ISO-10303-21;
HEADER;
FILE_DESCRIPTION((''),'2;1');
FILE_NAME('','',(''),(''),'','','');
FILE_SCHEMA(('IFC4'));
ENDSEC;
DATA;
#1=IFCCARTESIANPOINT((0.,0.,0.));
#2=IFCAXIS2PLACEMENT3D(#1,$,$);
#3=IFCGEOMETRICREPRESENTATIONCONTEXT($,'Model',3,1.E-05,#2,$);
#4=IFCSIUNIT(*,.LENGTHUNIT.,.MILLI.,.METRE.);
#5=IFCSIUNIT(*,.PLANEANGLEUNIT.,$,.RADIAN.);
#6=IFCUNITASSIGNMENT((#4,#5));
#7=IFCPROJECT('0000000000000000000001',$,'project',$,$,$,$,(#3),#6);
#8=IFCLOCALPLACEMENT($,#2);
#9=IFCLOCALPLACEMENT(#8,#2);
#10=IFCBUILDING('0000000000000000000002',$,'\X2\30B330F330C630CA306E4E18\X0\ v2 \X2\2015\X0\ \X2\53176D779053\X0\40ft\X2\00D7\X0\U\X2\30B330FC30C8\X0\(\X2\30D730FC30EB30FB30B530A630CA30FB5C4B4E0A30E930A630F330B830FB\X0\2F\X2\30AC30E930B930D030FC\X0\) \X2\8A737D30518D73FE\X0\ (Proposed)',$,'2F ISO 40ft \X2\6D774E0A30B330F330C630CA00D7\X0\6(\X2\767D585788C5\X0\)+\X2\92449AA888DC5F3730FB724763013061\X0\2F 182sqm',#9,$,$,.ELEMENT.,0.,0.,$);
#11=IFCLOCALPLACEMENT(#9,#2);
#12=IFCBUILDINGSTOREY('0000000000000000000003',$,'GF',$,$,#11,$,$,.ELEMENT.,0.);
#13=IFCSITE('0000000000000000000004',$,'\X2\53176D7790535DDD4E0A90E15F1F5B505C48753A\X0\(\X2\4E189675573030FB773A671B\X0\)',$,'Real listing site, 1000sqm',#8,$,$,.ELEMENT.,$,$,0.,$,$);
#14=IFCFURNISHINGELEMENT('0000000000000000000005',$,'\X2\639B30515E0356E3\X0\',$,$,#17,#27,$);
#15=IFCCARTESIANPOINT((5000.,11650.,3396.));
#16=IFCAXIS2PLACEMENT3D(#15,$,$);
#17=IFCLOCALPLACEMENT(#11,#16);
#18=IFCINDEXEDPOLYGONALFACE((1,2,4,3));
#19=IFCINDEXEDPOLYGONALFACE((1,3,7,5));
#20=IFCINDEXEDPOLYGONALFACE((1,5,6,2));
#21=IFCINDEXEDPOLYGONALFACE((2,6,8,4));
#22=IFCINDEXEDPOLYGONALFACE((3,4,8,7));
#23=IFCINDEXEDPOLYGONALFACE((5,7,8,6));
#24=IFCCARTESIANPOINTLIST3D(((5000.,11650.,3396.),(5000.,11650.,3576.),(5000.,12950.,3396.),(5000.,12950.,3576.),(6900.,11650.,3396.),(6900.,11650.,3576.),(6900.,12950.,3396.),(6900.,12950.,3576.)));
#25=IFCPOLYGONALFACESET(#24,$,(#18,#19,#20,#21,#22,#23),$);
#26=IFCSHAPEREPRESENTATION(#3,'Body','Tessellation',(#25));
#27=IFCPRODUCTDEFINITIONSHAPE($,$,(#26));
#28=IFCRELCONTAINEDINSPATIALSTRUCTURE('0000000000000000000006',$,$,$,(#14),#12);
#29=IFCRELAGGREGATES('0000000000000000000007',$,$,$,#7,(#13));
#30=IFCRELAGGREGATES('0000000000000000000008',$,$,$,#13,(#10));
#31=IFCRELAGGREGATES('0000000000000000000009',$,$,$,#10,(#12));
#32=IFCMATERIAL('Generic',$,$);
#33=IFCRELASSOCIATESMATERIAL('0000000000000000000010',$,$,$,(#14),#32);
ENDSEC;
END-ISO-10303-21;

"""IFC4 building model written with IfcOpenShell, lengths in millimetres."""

from ifc_helpers import new_model, si_unit, frame, frame_2d, origin, place, context, project, spatial, rectangle, extrude, material, element, save


model = new_model("IFC4")

# Units and contexts
model_context = context("Model", 3, precision=1e-05, world=origin())
ifc_project = project(units=[si_unit("LENGTHUNIT", "METRE", prefix="MILLI"), si_unit("PLANEANGLEUNIT", "RADIAN")], contexts=[model_context])

# Site, building, storey
site_placement = place(None, origin())
site = spatial("IfcSite", under=ifc_project, at=site_placement, Name="北海道川上郡弟子屈町(丘陵地・眺望)", ObjectType="Real listing site, 1000sqm", CompositionType="ELEMENT", RefElevation=0.0)
building_placement = place(site_placement, origin())
building = spatial("IfcBuilding", under=site, at=building_placement, Name="コンテナの丘 v2 ― 北海道40ft×Uコート(プール・サウナ・屋上ラウンジ・2Fガラスバー) 詳細再現 (Proposed)", ObjectType="2F ISO 40ft 海上コンテナ×6(白塗装)+鉄骨補強・片持ち2F 182sqm", CompositionType="ELEMENT", ElevationOfRefHeight=0.0, ElevationOfTerrain=0.0)
storey_placement = place(building_placement, origin())
storey = spatial("IfcBuildingStorey", under=building, at=storey_placement, Name="GF", CompositionType="ELEMENT", Elevation=0.0)

# Shared definitions
ifc_material = material(Name="Generic")

# Furnishing element
furnishing_1_placement = place(storey_placement, frame((5000.0, 11650.0, 3396.0)))
element("IfcFurnishingElement", 1, at=furnishing_1_placement, inside=storey, material=ifc_material, Name="掛け布団", context=model_context, shape_type="SweptSolid", body=[
    extrude(rectangle(XDim=1900.0, YDim=1300.0, at=frame_2d((950.0, 650.0))), frame((5000.0, 11650.0, 3396.0)), (0.0, 0.0, 1.0), 180.0),
])

save(model, "model.ifc")
